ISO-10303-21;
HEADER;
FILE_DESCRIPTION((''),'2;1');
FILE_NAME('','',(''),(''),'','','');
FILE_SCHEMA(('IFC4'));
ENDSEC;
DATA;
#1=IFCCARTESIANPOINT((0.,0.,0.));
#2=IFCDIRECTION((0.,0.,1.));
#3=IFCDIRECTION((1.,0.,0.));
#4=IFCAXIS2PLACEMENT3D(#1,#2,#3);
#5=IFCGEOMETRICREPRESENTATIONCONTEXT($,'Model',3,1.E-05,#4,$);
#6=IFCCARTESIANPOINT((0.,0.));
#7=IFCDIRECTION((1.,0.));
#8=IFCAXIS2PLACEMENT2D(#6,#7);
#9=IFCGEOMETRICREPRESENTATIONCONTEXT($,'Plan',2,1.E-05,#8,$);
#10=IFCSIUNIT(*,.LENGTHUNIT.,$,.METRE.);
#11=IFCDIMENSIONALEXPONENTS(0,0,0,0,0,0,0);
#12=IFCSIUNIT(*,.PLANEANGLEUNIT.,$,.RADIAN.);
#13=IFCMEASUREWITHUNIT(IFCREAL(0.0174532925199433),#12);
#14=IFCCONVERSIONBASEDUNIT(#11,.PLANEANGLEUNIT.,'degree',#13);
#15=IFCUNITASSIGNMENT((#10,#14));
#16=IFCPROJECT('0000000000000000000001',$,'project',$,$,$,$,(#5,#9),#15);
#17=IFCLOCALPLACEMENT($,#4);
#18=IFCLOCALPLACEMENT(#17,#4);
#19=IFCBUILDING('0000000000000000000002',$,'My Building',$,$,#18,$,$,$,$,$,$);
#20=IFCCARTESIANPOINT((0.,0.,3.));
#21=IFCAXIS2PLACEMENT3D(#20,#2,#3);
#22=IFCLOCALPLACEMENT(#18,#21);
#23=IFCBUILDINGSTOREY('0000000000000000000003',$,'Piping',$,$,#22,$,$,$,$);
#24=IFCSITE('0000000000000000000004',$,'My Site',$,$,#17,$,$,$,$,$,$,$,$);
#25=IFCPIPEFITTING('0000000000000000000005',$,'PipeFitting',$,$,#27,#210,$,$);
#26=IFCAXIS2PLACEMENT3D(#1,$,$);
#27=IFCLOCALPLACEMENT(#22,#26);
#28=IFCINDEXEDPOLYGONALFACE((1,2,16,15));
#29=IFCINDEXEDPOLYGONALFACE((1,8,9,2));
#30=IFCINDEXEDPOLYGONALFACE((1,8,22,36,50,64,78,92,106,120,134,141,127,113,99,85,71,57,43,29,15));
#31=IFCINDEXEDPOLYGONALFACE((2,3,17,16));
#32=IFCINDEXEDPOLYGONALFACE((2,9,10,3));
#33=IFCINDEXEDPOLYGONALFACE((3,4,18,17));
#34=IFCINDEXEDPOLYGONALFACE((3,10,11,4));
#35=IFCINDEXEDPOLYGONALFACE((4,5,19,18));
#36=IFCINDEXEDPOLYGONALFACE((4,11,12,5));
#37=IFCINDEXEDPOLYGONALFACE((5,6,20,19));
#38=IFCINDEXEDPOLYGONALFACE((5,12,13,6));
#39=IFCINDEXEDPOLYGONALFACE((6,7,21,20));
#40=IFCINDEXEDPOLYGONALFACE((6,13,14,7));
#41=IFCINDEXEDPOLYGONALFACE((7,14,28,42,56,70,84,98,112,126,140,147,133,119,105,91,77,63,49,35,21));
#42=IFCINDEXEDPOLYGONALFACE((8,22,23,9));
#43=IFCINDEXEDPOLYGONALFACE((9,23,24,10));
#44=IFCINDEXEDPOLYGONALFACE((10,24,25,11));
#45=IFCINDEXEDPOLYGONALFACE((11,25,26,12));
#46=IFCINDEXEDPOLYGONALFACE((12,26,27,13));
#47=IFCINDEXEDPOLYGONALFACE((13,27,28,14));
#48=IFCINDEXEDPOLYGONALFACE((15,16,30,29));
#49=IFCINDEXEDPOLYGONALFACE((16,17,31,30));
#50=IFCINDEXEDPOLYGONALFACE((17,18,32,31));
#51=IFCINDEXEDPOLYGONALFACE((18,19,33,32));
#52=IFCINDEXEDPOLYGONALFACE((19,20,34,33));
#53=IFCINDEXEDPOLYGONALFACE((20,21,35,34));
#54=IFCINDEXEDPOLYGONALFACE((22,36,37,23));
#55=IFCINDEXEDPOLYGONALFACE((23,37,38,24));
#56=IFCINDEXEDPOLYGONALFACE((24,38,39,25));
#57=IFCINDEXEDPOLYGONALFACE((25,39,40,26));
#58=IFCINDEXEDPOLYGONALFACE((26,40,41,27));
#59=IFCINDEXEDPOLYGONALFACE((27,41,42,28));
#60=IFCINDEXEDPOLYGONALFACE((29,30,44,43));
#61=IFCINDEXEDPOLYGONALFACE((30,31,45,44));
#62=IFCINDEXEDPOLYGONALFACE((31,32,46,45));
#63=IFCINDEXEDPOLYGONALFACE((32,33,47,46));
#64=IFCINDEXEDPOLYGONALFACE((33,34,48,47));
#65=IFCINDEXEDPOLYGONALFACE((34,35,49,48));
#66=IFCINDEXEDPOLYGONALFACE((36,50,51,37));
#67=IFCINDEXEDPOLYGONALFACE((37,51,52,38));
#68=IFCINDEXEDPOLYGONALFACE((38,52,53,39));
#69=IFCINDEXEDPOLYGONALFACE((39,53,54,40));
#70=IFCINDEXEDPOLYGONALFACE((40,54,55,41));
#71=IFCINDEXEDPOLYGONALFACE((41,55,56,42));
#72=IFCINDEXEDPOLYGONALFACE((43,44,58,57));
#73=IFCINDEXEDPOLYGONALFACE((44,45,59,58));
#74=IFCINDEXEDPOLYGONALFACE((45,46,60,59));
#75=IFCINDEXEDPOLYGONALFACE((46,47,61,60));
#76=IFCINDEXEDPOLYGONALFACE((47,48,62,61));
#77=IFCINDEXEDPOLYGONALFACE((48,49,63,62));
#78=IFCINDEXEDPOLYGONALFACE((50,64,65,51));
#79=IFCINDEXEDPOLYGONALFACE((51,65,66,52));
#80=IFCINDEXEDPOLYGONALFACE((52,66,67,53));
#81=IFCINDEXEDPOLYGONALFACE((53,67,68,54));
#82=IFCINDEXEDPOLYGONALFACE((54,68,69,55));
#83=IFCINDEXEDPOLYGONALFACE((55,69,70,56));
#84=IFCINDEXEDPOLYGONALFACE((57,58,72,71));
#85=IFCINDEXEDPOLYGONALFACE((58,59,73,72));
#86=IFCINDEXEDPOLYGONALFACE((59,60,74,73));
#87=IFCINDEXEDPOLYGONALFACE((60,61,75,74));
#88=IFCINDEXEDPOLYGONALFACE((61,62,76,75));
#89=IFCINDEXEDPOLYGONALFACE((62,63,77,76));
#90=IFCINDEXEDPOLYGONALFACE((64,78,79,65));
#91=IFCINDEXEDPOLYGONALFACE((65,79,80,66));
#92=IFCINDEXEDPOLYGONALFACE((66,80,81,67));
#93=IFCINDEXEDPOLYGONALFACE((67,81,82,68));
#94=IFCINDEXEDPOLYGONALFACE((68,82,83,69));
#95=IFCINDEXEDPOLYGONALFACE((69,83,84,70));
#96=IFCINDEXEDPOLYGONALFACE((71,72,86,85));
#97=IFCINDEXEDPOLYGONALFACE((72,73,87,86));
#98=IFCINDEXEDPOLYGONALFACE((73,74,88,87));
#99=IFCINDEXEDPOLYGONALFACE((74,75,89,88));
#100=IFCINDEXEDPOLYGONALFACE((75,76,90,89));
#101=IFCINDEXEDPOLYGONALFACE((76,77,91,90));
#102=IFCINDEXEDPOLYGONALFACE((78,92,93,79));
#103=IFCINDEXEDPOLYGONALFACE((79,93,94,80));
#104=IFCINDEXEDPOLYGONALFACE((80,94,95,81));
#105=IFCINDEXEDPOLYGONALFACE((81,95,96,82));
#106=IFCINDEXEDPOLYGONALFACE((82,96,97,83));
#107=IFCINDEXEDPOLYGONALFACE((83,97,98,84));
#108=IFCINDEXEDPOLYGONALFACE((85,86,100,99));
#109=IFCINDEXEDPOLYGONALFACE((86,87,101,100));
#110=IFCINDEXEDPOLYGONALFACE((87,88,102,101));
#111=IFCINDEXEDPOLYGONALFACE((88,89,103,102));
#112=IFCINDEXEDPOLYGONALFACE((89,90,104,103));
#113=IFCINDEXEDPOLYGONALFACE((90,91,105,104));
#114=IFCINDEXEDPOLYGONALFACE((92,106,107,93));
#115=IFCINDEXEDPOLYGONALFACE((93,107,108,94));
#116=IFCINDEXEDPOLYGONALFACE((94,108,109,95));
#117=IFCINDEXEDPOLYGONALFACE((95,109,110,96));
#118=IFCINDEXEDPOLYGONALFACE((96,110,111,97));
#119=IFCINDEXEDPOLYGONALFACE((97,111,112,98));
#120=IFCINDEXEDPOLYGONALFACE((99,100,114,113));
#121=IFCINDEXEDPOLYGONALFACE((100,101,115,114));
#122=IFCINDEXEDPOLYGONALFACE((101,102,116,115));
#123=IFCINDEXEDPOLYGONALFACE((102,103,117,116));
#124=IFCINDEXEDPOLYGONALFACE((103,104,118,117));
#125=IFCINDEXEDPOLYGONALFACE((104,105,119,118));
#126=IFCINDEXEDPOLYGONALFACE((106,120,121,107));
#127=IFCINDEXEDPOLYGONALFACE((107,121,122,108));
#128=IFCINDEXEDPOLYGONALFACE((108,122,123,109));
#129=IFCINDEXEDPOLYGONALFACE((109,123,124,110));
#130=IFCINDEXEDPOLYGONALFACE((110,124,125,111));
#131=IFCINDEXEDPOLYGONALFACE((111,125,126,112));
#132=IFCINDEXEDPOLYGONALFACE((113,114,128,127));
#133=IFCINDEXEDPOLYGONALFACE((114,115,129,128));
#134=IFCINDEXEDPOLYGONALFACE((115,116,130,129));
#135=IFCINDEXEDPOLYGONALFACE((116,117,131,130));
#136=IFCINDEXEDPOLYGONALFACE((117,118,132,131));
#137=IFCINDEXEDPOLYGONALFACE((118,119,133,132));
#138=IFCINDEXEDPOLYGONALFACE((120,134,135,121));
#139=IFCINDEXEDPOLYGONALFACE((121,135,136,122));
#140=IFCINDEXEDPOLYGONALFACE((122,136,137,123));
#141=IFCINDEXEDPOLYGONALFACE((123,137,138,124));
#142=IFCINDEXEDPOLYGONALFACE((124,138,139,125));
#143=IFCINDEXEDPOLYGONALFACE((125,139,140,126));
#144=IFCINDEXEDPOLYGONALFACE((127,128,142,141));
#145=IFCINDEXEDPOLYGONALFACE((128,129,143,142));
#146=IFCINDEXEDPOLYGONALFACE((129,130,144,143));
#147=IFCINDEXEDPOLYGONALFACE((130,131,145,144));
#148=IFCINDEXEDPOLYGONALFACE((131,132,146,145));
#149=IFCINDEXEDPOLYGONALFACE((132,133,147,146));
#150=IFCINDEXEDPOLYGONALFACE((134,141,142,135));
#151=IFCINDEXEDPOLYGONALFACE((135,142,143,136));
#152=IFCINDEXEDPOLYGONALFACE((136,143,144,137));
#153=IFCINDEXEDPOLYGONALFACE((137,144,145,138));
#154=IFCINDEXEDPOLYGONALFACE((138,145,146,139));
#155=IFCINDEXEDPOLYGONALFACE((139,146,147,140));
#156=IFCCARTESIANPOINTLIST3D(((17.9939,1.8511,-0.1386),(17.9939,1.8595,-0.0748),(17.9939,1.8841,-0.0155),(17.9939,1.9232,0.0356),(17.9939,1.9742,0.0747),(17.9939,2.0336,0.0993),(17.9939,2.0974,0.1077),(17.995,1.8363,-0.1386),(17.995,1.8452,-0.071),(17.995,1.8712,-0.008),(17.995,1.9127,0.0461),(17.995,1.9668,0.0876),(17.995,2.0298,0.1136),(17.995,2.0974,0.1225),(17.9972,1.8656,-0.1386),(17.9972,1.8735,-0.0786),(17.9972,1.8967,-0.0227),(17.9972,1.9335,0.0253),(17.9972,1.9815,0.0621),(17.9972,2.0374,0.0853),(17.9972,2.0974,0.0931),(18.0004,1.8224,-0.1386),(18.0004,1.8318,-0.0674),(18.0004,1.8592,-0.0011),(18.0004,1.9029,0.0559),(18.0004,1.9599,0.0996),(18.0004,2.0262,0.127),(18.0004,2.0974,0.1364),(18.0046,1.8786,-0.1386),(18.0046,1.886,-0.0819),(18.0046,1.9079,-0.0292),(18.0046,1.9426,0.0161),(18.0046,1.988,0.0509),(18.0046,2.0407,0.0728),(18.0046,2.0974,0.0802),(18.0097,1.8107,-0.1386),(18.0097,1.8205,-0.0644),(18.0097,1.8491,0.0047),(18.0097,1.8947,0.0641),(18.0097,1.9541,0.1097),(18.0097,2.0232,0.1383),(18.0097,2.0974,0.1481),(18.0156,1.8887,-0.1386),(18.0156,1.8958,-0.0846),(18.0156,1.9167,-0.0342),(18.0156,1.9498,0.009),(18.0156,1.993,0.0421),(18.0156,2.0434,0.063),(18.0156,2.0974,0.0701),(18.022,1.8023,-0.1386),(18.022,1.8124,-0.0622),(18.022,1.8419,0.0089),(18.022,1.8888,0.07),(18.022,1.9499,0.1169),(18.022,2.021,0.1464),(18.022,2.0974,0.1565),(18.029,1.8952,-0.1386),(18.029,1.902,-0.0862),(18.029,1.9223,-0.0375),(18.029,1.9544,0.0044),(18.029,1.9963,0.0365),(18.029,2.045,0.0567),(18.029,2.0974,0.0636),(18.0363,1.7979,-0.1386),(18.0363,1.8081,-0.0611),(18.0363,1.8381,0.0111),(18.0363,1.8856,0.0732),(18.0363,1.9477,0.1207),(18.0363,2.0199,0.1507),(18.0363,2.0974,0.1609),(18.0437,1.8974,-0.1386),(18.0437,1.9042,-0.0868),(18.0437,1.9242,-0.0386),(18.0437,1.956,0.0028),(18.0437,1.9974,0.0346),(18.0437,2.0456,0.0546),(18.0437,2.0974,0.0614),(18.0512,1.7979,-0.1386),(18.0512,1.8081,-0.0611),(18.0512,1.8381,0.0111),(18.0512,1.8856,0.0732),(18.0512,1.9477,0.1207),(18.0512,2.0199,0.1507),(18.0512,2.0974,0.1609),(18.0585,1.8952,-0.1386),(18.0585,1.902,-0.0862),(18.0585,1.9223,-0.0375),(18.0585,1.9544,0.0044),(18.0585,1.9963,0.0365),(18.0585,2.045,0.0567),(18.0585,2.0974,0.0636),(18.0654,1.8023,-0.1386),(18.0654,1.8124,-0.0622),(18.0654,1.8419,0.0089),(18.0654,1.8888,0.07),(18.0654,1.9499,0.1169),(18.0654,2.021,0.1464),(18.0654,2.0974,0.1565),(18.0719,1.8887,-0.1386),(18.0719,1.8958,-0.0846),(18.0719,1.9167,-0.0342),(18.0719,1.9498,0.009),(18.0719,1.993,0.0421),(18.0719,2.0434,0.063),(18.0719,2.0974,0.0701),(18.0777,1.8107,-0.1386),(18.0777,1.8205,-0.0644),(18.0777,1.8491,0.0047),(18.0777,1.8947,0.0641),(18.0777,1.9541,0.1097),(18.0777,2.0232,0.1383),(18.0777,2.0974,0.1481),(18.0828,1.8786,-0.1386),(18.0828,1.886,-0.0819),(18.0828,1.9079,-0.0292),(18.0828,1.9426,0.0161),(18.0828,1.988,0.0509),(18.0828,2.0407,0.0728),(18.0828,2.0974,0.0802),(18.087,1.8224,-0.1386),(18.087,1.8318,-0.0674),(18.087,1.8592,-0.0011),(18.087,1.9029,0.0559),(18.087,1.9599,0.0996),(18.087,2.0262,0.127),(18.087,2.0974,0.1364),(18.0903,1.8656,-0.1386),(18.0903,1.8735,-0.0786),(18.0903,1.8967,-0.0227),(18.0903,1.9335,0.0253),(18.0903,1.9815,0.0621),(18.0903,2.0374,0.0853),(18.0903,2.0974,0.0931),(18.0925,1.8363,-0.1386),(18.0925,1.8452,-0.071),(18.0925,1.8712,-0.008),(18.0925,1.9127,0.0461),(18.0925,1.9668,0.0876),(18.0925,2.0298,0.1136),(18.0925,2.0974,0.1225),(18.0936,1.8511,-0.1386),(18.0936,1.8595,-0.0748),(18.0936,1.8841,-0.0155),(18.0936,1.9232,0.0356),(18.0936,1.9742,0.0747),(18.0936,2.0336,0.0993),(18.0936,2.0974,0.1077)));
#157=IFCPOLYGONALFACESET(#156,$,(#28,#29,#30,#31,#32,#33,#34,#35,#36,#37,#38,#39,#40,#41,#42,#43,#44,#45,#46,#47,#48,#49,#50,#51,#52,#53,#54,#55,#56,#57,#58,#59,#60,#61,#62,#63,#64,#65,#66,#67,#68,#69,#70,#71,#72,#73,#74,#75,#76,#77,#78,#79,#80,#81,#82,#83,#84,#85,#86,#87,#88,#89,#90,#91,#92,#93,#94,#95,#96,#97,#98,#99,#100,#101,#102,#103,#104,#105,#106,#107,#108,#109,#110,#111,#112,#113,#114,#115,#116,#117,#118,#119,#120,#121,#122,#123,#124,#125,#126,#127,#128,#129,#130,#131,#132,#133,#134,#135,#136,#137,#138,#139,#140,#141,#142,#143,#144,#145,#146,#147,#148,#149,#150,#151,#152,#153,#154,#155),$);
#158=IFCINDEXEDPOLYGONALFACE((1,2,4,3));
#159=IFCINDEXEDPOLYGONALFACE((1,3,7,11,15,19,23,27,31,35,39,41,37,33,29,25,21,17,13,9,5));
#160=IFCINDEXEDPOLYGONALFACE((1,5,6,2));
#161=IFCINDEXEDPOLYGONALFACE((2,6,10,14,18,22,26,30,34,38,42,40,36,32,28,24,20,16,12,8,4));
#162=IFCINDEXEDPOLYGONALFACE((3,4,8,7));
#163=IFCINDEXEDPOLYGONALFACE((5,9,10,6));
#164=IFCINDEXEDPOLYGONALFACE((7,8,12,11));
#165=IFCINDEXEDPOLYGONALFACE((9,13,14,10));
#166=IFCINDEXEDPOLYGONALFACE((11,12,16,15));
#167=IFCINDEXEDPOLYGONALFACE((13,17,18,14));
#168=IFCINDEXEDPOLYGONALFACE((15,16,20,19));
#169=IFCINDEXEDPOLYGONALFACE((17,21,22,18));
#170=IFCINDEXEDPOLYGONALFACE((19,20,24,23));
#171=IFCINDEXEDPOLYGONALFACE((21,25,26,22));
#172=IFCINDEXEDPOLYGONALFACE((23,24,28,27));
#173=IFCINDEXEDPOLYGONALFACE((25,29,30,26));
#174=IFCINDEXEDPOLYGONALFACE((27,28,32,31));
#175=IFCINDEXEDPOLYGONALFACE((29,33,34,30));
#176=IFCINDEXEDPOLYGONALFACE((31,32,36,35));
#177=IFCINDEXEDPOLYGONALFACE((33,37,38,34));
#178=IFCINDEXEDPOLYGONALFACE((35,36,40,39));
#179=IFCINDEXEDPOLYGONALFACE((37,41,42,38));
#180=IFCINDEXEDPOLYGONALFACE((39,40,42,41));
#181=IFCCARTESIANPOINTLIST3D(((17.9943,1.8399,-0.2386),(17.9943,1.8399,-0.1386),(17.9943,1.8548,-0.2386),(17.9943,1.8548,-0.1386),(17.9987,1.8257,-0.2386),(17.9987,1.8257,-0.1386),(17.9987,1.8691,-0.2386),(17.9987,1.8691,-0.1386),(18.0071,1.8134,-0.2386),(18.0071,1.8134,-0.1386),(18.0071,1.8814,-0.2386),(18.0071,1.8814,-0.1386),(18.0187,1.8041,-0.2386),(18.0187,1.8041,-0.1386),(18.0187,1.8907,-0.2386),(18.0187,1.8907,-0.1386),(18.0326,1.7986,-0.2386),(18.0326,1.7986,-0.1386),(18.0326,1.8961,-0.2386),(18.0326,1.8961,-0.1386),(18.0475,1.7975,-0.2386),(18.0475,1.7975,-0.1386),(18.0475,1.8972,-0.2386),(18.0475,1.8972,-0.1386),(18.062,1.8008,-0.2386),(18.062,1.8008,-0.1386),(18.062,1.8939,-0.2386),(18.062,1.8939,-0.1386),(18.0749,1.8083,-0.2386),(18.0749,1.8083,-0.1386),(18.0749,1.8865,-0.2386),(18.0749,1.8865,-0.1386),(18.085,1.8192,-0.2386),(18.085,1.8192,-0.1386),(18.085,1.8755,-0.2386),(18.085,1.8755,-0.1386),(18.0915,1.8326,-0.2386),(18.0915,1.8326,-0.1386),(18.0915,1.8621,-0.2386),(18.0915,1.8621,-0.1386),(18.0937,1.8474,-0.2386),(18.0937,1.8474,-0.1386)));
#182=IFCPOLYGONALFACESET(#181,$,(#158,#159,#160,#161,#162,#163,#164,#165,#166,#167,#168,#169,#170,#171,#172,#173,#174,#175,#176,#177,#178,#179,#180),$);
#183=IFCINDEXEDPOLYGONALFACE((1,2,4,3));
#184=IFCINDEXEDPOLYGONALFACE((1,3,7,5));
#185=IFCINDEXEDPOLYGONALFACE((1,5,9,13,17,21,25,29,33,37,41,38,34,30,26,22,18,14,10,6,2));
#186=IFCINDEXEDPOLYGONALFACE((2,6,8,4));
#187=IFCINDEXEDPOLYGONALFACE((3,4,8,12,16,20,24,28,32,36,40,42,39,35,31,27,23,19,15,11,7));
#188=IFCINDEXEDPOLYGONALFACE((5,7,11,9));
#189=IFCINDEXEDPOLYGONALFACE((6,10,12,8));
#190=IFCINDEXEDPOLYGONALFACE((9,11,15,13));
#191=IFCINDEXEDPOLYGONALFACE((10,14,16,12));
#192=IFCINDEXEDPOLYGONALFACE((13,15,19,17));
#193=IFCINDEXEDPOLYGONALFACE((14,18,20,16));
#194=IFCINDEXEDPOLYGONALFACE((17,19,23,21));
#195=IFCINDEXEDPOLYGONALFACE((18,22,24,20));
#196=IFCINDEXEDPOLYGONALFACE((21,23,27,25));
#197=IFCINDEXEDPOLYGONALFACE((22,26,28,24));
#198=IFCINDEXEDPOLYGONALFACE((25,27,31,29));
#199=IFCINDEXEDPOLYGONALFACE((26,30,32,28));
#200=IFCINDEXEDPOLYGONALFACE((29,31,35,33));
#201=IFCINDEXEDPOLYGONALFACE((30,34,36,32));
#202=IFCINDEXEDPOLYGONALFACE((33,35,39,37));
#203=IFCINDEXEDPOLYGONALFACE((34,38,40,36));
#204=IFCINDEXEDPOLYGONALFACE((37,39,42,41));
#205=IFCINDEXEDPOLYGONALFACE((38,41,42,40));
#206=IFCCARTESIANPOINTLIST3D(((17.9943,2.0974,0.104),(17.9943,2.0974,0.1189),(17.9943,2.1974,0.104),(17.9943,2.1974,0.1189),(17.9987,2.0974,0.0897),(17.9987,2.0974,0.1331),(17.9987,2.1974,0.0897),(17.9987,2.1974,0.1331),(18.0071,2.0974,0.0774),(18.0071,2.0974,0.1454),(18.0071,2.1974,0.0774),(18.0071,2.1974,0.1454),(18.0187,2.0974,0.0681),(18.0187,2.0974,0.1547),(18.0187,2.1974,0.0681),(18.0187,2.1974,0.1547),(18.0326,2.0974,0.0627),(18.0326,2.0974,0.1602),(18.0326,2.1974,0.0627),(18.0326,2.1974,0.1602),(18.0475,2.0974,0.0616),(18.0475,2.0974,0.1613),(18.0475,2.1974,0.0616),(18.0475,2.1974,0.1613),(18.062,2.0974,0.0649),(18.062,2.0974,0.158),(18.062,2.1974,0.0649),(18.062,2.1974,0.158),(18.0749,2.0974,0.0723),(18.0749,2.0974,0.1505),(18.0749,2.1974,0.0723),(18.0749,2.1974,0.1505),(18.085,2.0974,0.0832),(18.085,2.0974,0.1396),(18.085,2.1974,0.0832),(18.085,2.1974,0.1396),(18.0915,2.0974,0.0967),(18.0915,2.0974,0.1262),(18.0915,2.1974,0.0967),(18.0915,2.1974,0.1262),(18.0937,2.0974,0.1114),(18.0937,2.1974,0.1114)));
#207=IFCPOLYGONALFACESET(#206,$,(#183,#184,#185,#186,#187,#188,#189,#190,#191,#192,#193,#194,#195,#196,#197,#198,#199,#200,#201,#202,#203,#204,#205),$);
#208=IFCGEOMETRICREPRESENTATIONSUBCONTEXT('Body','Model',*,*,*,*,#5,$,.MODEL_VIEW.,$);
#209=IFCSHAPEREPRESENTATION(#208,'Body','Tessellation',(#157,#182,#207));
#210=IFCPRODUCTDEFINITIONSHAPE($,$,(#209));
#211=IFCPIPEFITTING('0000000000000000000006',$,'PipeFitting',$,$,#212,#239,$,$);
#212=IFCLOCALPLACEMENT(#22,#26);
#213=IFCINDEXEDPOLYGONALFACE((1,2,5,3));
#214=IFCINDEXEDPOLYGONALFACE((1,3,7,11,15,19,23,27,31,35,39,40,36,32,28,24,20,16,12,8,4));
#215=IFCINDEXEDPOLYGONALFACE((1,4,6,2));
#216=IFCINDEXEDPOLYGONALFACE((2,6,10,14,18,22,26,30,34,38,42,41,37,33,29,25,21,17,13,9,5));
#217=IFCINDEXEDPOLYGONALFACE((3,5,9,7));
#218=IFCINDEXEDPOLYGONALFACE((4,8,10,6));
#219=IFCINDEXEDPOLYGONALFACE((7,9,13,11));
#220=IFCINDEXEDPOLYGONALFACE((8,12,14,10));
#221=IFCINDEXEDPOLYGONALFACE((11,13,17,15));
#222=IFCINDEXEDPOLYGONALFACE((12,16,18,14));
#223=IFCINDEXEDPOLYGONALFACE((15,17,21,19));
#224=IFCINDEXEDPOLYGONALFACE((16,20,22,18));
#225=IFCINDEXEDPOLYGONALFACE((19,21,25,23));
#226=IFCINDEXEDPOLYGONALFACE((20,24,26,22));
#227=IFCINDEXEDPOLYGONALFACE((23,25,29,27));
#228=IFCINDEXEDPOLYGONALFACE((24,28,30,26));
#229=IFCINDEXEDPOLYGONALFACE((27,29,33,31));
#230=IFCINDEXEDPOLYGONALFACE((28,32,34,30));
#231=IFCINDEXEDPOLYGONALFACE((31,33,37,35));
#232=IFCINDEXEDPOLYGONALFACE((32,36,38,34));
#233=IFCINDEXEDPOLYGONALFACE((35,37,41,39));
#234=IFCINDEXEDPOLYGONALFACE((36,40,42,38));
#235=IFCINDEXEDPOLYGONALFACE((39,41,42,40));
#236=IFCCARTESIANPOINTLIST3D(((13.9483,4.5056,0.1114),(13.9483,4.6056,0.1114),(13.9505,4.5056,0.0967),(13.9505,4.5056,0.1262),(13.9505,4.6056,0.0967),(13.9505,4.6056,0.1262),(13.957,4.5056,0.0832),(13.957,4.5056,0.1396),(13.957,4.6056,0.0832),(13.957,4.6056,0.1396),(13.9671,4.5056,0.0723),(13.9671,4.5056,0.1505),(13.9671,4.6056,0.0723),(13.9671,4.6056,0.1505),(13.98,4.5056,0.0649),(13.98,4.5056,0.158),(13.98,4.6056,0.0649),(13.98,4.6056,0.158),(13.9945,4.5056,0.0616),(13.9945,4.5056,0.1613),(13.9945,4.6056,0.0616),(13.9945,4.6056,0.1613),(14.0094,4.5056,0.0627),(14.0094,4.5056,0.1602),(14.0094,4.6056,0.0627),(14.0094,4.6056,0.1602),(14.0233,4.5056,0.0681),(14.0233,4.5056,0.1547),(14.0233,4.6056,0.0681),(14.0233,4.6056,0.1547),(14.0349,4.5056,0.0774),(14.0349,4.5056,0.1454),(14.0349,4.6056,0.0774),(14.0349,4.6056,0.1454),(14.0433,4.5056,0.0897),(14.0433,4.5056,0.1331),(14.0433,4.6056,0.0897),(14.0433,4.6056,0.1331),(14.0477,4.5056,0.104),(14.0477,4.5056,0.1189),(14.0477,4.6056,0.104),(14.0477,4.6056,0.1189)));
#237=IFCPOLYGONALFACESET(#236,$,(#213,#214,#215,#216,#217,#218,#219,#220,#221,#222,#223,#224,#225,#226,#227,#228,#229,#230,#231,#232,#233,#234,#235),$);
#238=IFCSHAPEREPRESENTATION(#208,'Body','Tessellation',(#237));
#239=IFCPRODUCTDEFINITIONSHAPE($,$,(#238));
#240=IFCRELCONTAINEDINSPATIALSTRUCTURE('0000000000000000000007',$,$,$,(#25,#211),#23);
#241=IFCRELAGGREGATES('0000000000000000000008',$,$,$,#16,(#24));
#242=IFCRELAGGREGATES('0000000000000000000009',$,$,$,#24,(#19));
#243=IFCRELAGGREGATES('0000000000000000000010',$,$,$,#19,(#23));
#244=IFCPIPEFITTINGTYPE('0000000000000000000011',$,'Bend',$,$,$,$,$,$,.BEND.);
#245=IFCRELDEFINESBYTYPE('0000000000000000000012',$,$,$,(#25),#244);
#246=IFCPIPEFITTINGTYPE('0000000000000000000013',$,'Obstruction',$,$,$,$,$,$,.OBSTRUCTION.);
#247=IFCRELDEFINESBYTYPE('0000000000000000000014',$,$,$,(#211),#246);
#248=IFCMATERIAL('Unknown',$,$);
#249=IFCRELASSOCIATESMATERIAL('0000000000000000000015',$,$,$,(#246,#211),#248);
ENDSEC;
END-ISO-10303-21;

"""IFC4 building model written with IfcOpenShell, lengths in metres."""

from ifc_helpers import new_model, entity, si_unit, converted_unit, frame, origin_with_axes, origin_2d_with_axis, place, context, subcontext, project, spatial, circle, extrude, source, transform, mapped, material, material_profile, profile_set, profile_usage, type_object, type_shapes, element, save


model = new_model("IFC4")

# Units and contexts
model_context = context("Model", 3, precision=1e-05, world=origin_with_axes())
plan_context = context("Plan", 2, precision=1e-05, world=origin_2d_with_axis())
body_context = subcontext(model_context, "Body", "Model", "MODEL_VIEW")
ifc_project = project(units=[si_unit("LENGTHUNIT", "METRE"), converted_unit("PLANEANGLEUNIT", "degree", entity("IfcReal", 0.0174532925199433), si_unit("PLANEANGLEUNIT", "RADIAN"), dimensions=[0, 0, 0, 0, 0, 0, 0])], contexts=[model_context, plan_context])

# Site, building, storey
site_placement = place(None, origin_with_axes())
site = spatial("IfcSite", under=ifc_project, at=site_placement, Name="My Site")
building_placement = place(site_placement, origin_with_axes())
building = spatial("IfcBuilding", under=site, at=building_placement, Name="My Building")
storey_placement = place(building_placement, frame((0.0, 0.0, 3.0), z_axis=(0.0, 0.0, 1.0), x_axis=(1.0, 0.0, 0.0)))
storey = spatial("IfcBuildingStorey", under=building, at=storey_placement, Name="Piping")

# Shared definitions
ifc_material = material(Name="Unknown")

# Pipe fittings
pipe_fitting_type_1 = type_object("IfcPipeFittingType", Name="Bend", PredefinedType="BEND")
shared_shape = source(origin_with_axes(), body_context, "Body", "SolidModel", [
    entity("IfcSweptDiskSolid", entity("IfcIndexedPolyCurve", entity("IfcCartesianPointList3D", [[0.0, 0.0, -0.1], [0.0, -0.0732, -0.2768], [0.0, -0.25, -0.35]]), [entity("IfcArcIndex", [1, 2, 3])]), 0.05),
    extrude(circle(Radius=0.05), origin_with_axes(), (0.0, 0.0, -1.0), 0.1),
    extrude(circle(Radius=0.05), frame((0.0, -0.25, -0.35), z_axis=(0.0, -1.0, 0.0), x_axis=(1.0, 0.0, 0.0)), (0.0, 0.0, 1.0), 0.1),
])
type_shapes(pipe_fitting_type_1, [shared_shape])
for number, where, z_axis, x_axis, name in (
    (1, (18.0437, 1.8474, -0.2386), (0.0, 0.0, -1.0), (1.0, 0.0, 0.0), "PipeFitting"),
):
    element("IfcPipeFitting", number, at=place(storey_placement, frame(where, z_axis=z_axis, x_axis=x_axis)), inside=storey, type_object=pipe_fitting_type_1, Name=name, context=body_context, shape_type="MappedRepresentation", body=[
        mapped(shared_shape, transform((0.0, 0.0, 0.0), x_axis=(1.0, 0.0, 0.0), y_axis=(0.0, 1.0, 0.0), z_axis=(0.0, 0.0, 1.0), scale=1.0)),
    ])
ifc_material_profile_1 = material_profile(ifc_material, circle(Radius=0.05))
ifc_profile_set_1 = profile_set([ifc_material_profile_1])
ifc_profile_usage_1 = profile_usage(ifc_profile_set_1, cardinal=16)
pipe_fitting_type_2 = type_object("IfcPipeFittingType", Name="Obstruction", PredefinedType="OBSTRUCTION", material=ifc_profile_set_1)
pipe_fitting_1_placement = place(storey_placement, frame((13.9983, 4.5056, 0.1114), z_axis=(0.0, 1.0, 0.0), x_axis=(-1.0, 0.0, 0.0)))
element("IfcPipeFitting", 2, at=pipe_fitting_1_placement, inside=storey, type_object=pipe_fitting_type_2, material=ifc_profile_usage_1, Name="PipeFitting", context=body_context, shape_type="SweptSolid", body=[
    extrude(circle(Radius=0.05), origin_with_axes(), (0.0, 0.0, 1.0), 0.1),
])

save(model, "model.ifc")
